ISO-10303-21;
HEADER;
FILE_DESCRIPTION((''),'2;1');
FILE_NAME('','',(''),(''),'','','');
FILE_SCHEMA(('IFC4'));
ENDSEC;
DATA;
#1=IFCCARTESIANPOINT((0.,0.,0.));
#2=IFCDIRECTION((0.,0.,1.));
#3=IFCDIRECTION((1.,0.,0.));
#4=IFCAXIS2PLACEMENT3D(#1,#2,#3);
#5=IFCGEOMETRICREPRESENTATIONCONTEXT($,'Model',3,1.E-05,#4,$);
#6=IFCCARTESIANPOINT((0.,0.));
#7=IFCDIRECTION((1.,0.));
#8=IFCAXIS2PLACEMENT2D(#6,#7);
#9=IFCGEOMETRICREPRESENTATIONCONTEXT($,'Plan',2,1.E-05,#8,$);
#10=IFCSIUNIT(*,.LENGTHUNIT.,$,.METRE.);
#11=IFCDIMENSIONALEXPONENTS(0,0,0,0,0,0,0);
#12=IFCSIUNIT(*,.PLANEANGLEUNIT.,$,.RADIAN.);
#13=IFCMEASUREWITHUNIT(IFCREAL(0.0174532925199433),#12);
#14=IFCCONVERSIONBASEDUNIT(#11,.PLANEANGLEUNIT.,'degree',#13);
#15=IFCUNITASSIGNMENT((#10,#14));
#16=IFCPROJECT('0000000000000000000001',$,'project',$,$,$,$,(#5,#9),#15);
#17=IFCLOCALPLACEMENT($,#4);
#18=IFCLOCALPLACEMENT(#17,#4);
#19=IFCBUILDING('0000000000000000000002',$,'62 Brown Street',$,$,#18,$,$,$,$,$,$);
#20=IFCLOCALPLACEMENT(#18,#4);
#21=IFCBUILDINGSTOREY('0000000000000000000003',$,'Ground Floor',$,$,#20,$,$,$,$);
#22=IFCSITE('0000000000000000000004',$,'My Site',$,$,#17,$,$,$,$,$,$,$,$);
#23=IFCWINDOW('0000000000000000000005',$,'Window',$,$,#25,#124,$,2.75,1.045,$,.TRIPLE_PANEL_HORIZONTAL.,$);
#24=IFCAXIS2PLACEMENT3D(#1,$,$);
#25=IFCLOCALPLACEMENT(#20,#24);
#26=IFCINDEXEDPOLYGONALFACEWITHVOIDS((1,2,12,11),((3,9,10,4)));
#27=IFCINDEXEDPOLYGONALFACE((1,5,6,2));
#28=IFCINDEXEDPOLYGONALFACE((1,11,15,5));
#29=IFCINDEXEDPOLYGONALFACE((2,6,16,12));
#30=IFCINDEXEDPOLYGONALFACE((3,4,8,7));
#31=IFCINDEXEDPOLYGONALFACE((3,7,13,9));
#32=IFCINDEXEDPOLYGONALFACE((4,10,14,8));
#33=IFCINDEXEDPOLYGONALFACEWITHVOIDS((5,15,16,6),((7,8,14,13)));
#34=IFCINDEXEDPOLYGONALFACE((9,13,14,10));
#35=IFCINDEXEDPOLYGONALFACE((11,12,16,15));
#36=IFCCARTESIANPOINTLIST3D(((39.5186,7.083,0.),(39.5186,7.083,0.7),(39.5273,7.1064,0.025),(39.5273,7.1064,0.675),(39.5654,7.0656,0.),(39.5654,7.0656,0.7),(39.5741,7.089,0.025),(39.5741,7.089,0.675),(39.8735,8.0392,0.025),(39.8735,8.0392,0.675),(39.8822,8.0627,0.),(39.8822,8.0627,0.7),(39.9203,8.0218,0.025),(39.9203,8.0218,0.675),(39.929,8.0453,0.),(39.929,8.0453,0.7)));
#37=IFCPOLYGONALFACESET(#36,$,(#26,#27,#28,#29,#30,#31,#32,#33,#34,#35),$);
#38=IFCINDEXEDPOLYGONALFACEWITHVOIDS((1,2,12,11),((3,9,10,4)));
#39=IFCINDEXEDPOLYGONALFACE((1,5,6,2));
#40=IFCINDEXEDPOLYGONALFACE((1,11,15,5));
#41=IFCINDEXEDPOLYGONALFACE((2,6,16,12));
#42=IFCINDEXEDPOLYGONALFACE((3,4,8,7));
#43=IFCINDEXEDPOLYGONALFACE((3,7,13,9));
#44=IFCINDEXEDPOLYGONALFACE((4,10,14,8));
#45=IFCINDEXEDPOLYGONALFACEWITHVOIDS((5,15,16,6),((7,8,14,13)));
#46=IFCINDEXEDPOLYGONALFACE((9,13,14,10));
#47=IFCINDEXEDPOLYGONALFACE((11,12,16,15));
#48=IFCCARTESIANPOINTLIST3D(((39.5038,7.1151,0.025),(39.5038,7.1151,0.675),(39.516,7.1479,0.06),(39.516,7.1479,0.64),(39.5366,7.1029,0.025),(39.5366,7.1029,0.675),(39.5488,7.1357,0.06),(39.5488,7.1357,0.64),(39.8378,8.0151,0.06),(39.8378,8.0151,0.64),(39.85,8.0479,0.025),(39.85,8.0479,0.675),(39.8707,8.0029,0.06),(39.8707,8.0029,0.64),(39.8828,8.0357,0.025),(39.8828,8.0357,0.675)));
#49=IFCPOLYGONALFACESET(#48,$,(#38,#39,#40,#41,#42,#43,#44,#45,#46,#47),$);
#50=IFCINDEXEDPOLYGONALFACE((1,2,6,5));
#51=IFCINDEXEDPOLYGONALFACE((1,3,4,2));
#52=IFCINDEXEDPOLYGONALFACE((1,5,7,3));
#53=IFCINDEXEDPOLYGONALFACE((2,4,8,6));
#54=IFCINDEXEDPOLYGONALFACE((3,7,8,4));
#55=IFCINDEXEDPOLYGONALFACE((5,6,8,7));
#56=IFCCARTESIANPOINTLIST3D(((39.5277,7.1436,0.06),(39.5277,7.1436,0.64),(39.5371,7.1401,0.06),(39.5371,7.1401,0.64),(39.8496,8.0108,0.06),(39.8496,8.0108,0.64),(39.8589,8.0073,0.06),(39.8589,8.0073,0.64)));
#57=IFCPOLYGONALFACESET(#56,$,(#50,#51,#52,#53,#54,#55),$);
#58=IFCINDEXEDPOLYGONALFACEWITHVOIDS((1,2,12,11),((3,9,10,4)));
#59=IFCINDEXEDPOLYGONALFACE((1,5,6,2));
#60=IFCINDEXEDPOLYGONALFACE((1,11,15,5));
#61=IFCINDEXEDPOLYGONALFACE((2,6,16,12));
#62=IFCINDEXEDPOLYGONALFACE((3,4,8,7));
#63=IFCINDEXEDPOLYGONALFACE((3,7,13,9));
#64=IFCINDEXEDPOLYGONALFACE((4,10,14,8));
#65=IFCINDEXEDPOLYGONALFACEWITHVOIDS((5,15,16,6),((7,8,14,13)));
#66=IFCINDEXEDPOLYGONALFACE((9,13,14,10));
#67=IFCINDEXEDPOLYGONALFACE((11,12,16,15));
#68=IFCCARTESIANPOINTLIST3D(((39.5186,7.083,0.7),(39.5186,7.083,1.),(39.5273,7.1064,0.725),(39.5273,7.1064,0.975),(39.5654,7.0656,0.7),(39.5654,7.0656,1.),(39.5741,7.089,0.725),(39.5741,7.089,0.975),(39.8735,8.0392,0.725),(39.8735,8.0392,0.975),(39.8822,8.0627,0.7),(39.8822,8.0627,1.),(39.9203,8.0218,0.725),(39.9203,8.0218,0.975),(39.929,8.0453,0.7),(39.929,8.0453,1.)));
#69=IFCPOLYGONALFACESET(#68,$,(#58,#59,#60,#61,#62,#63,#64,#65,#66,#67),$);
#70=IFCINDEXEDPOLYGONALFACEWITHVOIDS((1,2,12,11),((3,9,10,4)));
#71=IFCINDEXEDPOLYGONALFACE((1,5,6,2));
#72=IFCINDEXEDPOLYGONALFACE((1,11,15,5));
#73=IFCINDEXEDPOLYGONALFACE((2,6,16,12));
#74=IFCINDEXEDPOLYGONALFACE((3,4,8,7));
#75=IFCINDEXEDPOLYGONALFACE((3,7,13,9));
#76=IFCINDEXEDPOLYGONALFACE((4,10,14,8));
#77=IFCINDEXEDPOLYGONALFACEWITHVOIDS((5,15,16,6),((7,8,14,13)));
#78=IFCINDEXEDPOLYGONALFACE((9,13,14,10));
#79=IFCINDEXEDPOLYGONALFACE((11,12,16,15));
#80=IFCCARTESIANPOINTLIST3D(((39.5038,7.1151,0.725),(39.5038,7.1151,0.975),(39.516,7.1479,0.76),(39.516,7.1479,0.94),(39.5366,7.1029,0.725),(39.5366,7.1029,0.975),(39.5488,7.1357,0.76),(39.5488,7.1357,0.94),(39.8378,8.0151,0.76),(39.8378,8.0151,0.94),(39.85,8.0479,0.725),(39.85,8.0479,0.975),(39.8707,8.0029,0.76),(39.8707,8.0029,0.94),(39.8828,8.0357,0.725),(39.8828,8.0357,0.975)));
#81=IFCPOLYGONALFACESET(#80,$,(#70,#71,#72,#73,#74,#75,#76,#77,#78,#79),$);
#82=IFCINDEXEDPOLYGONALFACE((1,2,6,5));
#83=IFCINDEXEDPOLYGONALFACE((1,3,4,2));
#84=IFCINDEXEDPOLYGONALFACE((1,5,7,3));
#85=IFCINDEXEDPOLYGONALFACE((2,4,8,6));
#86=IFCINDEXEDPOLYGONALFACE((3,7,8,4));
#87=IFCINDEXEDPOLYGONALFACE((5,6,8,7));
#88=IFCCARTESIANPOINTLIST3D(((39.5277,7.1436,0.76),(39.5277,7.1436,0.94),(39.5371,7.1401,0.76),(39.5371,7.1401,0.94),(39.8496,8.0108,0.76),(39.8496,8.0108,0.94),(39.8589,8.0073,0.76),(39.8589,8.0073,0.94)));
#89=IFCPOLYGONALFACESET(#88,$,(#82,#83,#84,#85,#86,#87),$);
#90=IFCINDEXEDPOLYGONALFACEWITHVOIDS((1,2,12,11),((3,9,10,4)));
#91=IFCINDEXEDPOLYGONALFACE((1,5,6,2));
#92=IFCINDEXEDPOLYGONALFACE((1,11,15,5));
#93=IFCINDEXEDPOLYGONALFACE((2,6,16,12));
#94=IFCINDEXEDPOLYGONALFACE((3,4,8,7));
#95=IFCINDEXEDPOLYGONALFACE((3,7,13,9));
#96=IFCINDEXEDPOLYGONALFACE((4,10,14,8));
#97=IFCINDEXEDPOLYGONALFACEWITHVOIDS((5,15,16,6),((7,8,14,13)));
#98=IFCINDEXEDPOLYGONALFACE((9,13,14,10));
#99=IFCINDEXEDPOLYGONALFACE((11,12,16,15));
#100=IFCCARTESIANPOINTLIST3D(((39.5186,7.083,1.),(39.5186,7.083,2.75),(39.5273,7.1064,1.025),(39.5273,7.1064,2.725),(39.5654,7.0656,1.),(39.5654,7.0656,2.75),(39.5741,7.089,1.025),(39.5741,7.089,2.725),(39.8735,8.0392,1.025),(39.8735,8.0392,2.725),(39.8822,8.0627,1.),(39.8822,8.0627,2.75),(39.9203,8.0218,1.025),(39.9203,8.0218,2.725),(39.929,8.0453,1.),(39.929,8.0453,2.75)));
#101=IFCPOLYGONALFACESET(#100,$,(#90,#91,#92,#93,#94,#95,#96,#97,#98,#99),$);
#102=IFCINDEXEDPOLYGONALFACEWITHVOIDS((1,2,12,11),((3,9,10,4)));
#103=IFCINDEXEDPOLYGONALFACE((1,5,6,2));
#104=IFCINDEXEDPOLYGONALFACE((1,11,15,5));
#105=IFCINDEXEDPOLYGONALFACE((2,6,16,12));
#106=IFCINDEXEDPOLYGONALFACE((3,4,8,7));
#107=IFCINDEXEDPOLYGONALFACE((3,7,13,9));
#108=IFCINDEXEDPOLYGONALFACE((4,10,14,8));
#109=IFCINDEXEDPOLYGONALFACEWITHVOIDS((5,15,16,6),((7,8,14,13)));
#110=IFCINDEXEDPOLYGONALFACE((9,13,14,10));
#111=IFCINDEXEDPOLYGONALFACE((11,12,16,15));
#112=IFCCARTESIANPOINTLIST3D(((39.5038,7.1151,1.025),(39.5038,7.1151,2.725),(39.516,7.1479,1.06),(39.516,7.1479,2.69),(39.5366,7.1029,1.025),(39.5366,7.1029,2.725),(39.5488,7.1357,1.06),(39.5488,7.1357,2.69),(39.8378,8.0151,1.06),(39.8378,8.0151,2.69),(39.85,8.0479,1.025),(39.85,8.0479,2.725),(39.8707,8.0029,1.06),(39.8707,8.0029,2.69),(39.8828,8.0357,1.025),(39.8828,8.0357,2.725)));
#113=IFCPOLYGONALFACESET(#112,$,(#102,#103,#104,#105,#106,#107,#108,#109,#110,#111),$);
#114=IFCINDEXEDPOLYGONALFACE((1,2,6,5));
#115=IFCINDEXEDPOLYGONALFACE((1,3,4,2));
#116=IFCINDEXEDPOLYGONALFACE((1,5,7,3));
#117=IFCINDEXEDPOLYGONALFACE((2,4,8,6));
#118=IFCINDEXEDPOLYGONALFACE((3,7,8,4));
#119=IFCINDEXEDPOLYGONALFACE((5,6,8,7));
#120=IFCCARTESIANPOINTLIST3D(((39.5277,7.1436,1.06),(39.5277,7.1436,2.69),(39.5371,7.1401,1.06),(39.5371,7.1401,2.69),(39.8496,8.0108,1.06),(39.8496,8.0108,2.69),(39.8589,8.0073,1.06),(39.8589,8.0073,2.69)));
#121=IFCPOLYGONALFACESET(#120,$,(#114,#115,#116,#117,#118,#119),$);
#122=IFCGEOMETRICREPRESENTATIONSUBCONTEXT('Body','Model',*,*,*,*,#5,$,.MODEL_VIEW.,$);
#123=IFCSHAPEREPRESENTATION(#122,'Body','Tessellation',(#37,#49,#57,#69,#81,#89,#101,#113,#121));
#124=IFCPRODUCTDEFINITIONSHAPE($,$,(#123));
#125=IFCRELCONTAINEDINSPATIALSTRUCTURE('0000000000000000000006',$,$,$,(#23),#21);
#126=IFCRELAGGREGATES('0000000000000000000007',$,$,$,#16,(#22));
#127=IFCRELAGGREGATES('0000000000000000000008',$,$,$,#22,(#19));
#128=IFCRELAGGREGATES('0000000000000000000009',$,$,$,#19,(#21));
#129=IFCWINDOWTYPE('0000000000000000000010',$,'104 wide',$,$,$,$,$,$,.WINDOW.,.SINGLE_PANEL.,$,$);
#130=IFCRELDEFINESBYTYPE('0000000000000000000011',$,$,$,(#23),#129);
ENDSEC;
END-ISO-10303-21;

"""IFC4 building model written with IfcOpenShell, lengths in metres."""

from ifc_helpers import new_model, entity, si_unit, converted_unit, frame, origin_with_axes, origin_2d_with_axis, place, context, subcontext, project, spatial, line, indexed_curve, outline, extrude, shape, source, transform, mapped, type_object, type_shapes, element, save


model = new_model("IFC4")

# Units and contexts
model_context = context("Model", 3, precision=1e-05, world=origin_with_axes())
plan_context = context("Plan", 2, precision=1e-05, world=origin_2d_with_axis())
body_context_1 = subcontext(model_context, "Body", "Model", "MODEL_VIEW")
body_context_2 = subcontext(plan_context, "Body", "Plan", "PLAN_VIEW")
ifc_project = project(units=[si_unit("LENGTHUNIT", "METRE"), converted_unit("PLANEANGLEUNIT", "degree", entity("IfcReal", 0.0174532925199433), si_unit("PLANEANGLEUNIT", "RADIAN"), dimensions=[0, 0, 0, 0, 0, 0, 0])], contexts=[model_context, plan_context])

# Site, building, storey
site_placement = place(None, origin_with_axes())
site = spatial("IfcSite", under=ifc_project, at=site_placement, Name="My Site")
building_placement = place(site_placement, origin_with_axes())
building = spatial("IfcBuilding", under=site, at=building_placement, Name="62 Brown Street")
storey_placement = place(building_placement, origin_with_axes())
storey = spatial("IfcBuildingStorey", under=building, at=storey_placement, Name="Ground Floor")

# Window
window_type_1 = type_object("IfcWindowType", Name="104 wide", PartitioningType="SINGLE_PANEL", PredefinedType="WINDOW")
shared_shape_1 = source(origin_with_axes(), body_context_1, "Body", "SweptSolid", [
    extrude(outline(indexed_curve([(0.0, 0.0), (1.045, 0.0), (1.045, 0.7), (0.0, 0.7)], segments=[line(1, 2, 3, 4, 1)]), holes=[indexed_curve([(0.025, 0.025), (1.02, 0.025), (1.02, 0.675), (0.025, 0.675)], segments=[line(1, 2, 3, 4, 1)])]), frame((0.0, 0.15, 0.0), z_axis=(0.0, -1.0, 0.0), x_axis=(1.0, 0.0, 0.0)), (0.0, 0.0, -1.0), 0.05),
    extrude(outline(indexed_curve([(0.0, 0.0), (0.995, 0.0), (0.995, 0.65), (0.0, 0.65)], segments=[line(1, 2, 3, 4, 1)]), holes=[indexed_curve([(0.035, 0.035), (0.96, 0.035), (0.96, 0.615), (0.035, 0.615)], segments=[line(1, 2, 3, 4, 1)])]), frame((0.025, 0.19, 0.025), z_axis=(0.0, -1.0, 0.0), x_axis=(1.0, 0.0, 0.0)), (0.0, 0.0, -1.0), 0.035),
    extrude(outline(indexed_curve([(0.035, 0.035), (0.96, 0.035), (0.96, 0.615), (0.035, 0.615)], segments=[line(1, 2, 3, 4, 1)])), frame((0.025, 0.2025, 0.025), z_axis=(0.0, -1.0, 0.0), x_axis=(1.0, 0.0, 0.0)), (0.0, 0.0, -1.0), 0.01),
    extrude(outline(indexed_curve([(0.0, 0.0), (1.045, 0.0), (1.045, 0.3), (0.0, 0.3)], segments=[line(1, 2, 3, 4, 1)]), holes=[indexed_curve([(0.025, 0.025), (1.02, 0.025), (1.02, 0.275), (0.025, 0.275)], segments=[line(1, 2, 3, 4, 1)])]), frame((0.0, 0.15, 0.7), z_axis=(0.0, -1.0, 0.0), x_axis=(1.0, 0.0, 0.0)), (0.0, 0.0, -1.0), 0.05),
    extrude(outline(indexed_curve([(0.0, 0.0), (0.995, 0.0), (0.995, 0.25), (0.0, 0.25)], segments=[line(1, 2, 3, 4, 1)]), holes=[indexed_curve([(0.035, 0.035), (0.96, 0.035), (0.96, 0.215), (0.035, 0.215)], segments=[line(1, 2, 3, 4, 1)])]), frame((0.025, 0.19, 0.725), z_axis=(0.0, -1.0, 0.0), x_axis=(1.0, 0.0, 0.0)), (0.0, 0.0, -1.0), 0.035),
    extrude(outline(indexed_curve([(0.035, 0.035), (0.96, 0.035), (0.96, 0.215), (0.035, 0.215)], segments=[line(1, 2, 3, 4, 1)])), frame((0.025, 0.2025, 0.725), z_axis=(0.0, -1.0, 0.0), x_axis=(1.0, 0.0, 0.0)), (0.0, 0.0, -1.0), 0.01),
    extrude(outline(indexed_curve([(0.0, 0.0), (1.045, 0.0), (1.045, 1.75), (0.0, 1.75)], segments=[line(1, 2, 3, 4, 1)]), holes=[indexed_curve([(0.025, 0.025), (1.02, 0.025), (1.02, 1.725), (0.025, 1.725)], segments=[line(1, 2, 3, 4, 1)])]), frame((0.0, 0.15, 1.0), z_axis=(0.0, -1.0, 0.0), x_axis=(1.0, 0.0, 0.0)), (0.0, 0.0, -1.0), 0.05),
    extrude(outline(indexed_curve([(0.0, 0.0), (0.995, 0.0), (0.995, 1.7), (0.0, 1.7)], segments=[line(1, 2, 3, 4, 1)]), holes=[indexed_curve([(0.035, 0.035), (0.96, 0.035), (0.96, 1.665), (0.035, 1.665)], segments=[line(1, 2, 3, 4, 1)])]), frame((0.025, 0.19, 1.025), z_axis=(0.0, -1.0, 0.0), x_axis=(1.0, 0.0, 0.0)), (0.0, 0.0, -1.0), 0.035),
    extrude(outline(indexed_curve([(0.035, 0.035), (0.96, 0.035), (0.96, 1.665), (0.035, 1.665)], segments=[line(1, 2, 3, 4, 1)])), frame((0.025, 0.2025, 1.025), z_axis=(0.0, -1.0, 0.0), x_axis=(1.0, 0.0, 0.0)), (0.0, 0.0, -1.0), 0.01),
])
shared_shape_2 = source(origin_with_axes(), body_context_2, "Body", "Curve2D", [
    entity("IfcIndexedPolyCurve", entity("IfcCartesianPointList2D", [[0.025, 0.15], [1.02, 0.15]])),
    entity("IfcIndexedPolyCurve", entity("IfcCartesianPointList2D", [[0.0, 0.2], [0.025, 0.2], [0.025, 0.15], [0.0, 0.15]]), [entity("IfcLineIndex", [1, 2, 3, 4, 1])]),
    entity("IfcIndexedPolyCurve", entity("IfcCartesianPointList2D", [[1.045, 0.2], [1.02, 0.2], [1.02, 0.15], [1.045, 0.15]]), [entity("IfcLineIndex", [1, 2, 3, 4, 1])]),
    entity("IfcIndexedPolyCurve", entity("IfcCartesianPointList2D", [[0.025, 0.19], [0.06, 0.19], [0.06, 0.225], [0.025, 0.225]]), [entity("IfcLineIndex", [1, 2, 3, 4, 1])]),
    entity("IfcIndexedPolyCurve", entity("IfcCartesianPointList2D", [[1.02, 0.19], [0.985, 0.19], [0.985, 0.225], [1.02, 0.225]]), [entity("IfcLineIndex", [1, 2, 3, 4, 1])]),
    entity("IfcIndexedPolyCurve", entity("IfcCartesianPointList2D", [[0.06, 0.19], [0.985, 0.19]])),
    entity("IfcIndexedPolyCurve", entity("IfcCartesianPointList2D", [[0.06, 0.225], [0.985, 0.225]])),
    entity("IfcIndexedPolyCurve", entity("IfcCartesianPointList2D", [[0.06, 0.2075], [0.985, 0.2075]])),
])
type_shapes(window_type_1, [shared_shape_1, shared_shape_2])
placement_1 = place(storey_placement, frame((39.024, 5.1755, 0.0), z_axis=(0.0, 0.0, 1.0), x_axis=(0.347944, 0.937515, 0.0)))
placement_2 = place(placement_1, frame((1.9604, 0.0, 0.0), z_axis=(0.0, 0.0, 1.0), x_axis=(1.0, 0.0, 0.0)))
for number, where, z_axis, x_axis, name in (
    (1, (0.0, 0.0, 0.0), (0.0, 0.0, 1.0), (1.0, 0.0, 0.0), "Window"),
):
    element("IfcWindow", number, at=place(placement_2, frame(where, z_axis=z_axis, x_axis=x_axis)), inside=storey, type_object=window_type_1, Name=name, OverallHeight=2.75, OverallWidth=1.045, PartitioningType="TRIPLE_PANEL_HORIZONTAL", shapes=[
        shape(body_context_1, "Body", "MappedRepresentation", [mapped(shared_shape_1, transform((0.0, 0.0, 0.0), x_axis=(1.0, 0.0, 0.0), y_axis=(0.0, 1.0, 0.0), z_axis=(0.0, 0.0, 1.0), scale=1.0))]),
        shape(body_context_2, "Body", "MappedRepresentation", [mapped(shared_shape_2, transform((0.0, 0.0, 0.0), x_axis=(1.0, 0.0, 0.0), y_axis=(0.0, 1.0, 0.0), z_axis=(0.0, 0.0, 1.0), scale=1.0))]),
    ])

save(model, "model.ifc")
